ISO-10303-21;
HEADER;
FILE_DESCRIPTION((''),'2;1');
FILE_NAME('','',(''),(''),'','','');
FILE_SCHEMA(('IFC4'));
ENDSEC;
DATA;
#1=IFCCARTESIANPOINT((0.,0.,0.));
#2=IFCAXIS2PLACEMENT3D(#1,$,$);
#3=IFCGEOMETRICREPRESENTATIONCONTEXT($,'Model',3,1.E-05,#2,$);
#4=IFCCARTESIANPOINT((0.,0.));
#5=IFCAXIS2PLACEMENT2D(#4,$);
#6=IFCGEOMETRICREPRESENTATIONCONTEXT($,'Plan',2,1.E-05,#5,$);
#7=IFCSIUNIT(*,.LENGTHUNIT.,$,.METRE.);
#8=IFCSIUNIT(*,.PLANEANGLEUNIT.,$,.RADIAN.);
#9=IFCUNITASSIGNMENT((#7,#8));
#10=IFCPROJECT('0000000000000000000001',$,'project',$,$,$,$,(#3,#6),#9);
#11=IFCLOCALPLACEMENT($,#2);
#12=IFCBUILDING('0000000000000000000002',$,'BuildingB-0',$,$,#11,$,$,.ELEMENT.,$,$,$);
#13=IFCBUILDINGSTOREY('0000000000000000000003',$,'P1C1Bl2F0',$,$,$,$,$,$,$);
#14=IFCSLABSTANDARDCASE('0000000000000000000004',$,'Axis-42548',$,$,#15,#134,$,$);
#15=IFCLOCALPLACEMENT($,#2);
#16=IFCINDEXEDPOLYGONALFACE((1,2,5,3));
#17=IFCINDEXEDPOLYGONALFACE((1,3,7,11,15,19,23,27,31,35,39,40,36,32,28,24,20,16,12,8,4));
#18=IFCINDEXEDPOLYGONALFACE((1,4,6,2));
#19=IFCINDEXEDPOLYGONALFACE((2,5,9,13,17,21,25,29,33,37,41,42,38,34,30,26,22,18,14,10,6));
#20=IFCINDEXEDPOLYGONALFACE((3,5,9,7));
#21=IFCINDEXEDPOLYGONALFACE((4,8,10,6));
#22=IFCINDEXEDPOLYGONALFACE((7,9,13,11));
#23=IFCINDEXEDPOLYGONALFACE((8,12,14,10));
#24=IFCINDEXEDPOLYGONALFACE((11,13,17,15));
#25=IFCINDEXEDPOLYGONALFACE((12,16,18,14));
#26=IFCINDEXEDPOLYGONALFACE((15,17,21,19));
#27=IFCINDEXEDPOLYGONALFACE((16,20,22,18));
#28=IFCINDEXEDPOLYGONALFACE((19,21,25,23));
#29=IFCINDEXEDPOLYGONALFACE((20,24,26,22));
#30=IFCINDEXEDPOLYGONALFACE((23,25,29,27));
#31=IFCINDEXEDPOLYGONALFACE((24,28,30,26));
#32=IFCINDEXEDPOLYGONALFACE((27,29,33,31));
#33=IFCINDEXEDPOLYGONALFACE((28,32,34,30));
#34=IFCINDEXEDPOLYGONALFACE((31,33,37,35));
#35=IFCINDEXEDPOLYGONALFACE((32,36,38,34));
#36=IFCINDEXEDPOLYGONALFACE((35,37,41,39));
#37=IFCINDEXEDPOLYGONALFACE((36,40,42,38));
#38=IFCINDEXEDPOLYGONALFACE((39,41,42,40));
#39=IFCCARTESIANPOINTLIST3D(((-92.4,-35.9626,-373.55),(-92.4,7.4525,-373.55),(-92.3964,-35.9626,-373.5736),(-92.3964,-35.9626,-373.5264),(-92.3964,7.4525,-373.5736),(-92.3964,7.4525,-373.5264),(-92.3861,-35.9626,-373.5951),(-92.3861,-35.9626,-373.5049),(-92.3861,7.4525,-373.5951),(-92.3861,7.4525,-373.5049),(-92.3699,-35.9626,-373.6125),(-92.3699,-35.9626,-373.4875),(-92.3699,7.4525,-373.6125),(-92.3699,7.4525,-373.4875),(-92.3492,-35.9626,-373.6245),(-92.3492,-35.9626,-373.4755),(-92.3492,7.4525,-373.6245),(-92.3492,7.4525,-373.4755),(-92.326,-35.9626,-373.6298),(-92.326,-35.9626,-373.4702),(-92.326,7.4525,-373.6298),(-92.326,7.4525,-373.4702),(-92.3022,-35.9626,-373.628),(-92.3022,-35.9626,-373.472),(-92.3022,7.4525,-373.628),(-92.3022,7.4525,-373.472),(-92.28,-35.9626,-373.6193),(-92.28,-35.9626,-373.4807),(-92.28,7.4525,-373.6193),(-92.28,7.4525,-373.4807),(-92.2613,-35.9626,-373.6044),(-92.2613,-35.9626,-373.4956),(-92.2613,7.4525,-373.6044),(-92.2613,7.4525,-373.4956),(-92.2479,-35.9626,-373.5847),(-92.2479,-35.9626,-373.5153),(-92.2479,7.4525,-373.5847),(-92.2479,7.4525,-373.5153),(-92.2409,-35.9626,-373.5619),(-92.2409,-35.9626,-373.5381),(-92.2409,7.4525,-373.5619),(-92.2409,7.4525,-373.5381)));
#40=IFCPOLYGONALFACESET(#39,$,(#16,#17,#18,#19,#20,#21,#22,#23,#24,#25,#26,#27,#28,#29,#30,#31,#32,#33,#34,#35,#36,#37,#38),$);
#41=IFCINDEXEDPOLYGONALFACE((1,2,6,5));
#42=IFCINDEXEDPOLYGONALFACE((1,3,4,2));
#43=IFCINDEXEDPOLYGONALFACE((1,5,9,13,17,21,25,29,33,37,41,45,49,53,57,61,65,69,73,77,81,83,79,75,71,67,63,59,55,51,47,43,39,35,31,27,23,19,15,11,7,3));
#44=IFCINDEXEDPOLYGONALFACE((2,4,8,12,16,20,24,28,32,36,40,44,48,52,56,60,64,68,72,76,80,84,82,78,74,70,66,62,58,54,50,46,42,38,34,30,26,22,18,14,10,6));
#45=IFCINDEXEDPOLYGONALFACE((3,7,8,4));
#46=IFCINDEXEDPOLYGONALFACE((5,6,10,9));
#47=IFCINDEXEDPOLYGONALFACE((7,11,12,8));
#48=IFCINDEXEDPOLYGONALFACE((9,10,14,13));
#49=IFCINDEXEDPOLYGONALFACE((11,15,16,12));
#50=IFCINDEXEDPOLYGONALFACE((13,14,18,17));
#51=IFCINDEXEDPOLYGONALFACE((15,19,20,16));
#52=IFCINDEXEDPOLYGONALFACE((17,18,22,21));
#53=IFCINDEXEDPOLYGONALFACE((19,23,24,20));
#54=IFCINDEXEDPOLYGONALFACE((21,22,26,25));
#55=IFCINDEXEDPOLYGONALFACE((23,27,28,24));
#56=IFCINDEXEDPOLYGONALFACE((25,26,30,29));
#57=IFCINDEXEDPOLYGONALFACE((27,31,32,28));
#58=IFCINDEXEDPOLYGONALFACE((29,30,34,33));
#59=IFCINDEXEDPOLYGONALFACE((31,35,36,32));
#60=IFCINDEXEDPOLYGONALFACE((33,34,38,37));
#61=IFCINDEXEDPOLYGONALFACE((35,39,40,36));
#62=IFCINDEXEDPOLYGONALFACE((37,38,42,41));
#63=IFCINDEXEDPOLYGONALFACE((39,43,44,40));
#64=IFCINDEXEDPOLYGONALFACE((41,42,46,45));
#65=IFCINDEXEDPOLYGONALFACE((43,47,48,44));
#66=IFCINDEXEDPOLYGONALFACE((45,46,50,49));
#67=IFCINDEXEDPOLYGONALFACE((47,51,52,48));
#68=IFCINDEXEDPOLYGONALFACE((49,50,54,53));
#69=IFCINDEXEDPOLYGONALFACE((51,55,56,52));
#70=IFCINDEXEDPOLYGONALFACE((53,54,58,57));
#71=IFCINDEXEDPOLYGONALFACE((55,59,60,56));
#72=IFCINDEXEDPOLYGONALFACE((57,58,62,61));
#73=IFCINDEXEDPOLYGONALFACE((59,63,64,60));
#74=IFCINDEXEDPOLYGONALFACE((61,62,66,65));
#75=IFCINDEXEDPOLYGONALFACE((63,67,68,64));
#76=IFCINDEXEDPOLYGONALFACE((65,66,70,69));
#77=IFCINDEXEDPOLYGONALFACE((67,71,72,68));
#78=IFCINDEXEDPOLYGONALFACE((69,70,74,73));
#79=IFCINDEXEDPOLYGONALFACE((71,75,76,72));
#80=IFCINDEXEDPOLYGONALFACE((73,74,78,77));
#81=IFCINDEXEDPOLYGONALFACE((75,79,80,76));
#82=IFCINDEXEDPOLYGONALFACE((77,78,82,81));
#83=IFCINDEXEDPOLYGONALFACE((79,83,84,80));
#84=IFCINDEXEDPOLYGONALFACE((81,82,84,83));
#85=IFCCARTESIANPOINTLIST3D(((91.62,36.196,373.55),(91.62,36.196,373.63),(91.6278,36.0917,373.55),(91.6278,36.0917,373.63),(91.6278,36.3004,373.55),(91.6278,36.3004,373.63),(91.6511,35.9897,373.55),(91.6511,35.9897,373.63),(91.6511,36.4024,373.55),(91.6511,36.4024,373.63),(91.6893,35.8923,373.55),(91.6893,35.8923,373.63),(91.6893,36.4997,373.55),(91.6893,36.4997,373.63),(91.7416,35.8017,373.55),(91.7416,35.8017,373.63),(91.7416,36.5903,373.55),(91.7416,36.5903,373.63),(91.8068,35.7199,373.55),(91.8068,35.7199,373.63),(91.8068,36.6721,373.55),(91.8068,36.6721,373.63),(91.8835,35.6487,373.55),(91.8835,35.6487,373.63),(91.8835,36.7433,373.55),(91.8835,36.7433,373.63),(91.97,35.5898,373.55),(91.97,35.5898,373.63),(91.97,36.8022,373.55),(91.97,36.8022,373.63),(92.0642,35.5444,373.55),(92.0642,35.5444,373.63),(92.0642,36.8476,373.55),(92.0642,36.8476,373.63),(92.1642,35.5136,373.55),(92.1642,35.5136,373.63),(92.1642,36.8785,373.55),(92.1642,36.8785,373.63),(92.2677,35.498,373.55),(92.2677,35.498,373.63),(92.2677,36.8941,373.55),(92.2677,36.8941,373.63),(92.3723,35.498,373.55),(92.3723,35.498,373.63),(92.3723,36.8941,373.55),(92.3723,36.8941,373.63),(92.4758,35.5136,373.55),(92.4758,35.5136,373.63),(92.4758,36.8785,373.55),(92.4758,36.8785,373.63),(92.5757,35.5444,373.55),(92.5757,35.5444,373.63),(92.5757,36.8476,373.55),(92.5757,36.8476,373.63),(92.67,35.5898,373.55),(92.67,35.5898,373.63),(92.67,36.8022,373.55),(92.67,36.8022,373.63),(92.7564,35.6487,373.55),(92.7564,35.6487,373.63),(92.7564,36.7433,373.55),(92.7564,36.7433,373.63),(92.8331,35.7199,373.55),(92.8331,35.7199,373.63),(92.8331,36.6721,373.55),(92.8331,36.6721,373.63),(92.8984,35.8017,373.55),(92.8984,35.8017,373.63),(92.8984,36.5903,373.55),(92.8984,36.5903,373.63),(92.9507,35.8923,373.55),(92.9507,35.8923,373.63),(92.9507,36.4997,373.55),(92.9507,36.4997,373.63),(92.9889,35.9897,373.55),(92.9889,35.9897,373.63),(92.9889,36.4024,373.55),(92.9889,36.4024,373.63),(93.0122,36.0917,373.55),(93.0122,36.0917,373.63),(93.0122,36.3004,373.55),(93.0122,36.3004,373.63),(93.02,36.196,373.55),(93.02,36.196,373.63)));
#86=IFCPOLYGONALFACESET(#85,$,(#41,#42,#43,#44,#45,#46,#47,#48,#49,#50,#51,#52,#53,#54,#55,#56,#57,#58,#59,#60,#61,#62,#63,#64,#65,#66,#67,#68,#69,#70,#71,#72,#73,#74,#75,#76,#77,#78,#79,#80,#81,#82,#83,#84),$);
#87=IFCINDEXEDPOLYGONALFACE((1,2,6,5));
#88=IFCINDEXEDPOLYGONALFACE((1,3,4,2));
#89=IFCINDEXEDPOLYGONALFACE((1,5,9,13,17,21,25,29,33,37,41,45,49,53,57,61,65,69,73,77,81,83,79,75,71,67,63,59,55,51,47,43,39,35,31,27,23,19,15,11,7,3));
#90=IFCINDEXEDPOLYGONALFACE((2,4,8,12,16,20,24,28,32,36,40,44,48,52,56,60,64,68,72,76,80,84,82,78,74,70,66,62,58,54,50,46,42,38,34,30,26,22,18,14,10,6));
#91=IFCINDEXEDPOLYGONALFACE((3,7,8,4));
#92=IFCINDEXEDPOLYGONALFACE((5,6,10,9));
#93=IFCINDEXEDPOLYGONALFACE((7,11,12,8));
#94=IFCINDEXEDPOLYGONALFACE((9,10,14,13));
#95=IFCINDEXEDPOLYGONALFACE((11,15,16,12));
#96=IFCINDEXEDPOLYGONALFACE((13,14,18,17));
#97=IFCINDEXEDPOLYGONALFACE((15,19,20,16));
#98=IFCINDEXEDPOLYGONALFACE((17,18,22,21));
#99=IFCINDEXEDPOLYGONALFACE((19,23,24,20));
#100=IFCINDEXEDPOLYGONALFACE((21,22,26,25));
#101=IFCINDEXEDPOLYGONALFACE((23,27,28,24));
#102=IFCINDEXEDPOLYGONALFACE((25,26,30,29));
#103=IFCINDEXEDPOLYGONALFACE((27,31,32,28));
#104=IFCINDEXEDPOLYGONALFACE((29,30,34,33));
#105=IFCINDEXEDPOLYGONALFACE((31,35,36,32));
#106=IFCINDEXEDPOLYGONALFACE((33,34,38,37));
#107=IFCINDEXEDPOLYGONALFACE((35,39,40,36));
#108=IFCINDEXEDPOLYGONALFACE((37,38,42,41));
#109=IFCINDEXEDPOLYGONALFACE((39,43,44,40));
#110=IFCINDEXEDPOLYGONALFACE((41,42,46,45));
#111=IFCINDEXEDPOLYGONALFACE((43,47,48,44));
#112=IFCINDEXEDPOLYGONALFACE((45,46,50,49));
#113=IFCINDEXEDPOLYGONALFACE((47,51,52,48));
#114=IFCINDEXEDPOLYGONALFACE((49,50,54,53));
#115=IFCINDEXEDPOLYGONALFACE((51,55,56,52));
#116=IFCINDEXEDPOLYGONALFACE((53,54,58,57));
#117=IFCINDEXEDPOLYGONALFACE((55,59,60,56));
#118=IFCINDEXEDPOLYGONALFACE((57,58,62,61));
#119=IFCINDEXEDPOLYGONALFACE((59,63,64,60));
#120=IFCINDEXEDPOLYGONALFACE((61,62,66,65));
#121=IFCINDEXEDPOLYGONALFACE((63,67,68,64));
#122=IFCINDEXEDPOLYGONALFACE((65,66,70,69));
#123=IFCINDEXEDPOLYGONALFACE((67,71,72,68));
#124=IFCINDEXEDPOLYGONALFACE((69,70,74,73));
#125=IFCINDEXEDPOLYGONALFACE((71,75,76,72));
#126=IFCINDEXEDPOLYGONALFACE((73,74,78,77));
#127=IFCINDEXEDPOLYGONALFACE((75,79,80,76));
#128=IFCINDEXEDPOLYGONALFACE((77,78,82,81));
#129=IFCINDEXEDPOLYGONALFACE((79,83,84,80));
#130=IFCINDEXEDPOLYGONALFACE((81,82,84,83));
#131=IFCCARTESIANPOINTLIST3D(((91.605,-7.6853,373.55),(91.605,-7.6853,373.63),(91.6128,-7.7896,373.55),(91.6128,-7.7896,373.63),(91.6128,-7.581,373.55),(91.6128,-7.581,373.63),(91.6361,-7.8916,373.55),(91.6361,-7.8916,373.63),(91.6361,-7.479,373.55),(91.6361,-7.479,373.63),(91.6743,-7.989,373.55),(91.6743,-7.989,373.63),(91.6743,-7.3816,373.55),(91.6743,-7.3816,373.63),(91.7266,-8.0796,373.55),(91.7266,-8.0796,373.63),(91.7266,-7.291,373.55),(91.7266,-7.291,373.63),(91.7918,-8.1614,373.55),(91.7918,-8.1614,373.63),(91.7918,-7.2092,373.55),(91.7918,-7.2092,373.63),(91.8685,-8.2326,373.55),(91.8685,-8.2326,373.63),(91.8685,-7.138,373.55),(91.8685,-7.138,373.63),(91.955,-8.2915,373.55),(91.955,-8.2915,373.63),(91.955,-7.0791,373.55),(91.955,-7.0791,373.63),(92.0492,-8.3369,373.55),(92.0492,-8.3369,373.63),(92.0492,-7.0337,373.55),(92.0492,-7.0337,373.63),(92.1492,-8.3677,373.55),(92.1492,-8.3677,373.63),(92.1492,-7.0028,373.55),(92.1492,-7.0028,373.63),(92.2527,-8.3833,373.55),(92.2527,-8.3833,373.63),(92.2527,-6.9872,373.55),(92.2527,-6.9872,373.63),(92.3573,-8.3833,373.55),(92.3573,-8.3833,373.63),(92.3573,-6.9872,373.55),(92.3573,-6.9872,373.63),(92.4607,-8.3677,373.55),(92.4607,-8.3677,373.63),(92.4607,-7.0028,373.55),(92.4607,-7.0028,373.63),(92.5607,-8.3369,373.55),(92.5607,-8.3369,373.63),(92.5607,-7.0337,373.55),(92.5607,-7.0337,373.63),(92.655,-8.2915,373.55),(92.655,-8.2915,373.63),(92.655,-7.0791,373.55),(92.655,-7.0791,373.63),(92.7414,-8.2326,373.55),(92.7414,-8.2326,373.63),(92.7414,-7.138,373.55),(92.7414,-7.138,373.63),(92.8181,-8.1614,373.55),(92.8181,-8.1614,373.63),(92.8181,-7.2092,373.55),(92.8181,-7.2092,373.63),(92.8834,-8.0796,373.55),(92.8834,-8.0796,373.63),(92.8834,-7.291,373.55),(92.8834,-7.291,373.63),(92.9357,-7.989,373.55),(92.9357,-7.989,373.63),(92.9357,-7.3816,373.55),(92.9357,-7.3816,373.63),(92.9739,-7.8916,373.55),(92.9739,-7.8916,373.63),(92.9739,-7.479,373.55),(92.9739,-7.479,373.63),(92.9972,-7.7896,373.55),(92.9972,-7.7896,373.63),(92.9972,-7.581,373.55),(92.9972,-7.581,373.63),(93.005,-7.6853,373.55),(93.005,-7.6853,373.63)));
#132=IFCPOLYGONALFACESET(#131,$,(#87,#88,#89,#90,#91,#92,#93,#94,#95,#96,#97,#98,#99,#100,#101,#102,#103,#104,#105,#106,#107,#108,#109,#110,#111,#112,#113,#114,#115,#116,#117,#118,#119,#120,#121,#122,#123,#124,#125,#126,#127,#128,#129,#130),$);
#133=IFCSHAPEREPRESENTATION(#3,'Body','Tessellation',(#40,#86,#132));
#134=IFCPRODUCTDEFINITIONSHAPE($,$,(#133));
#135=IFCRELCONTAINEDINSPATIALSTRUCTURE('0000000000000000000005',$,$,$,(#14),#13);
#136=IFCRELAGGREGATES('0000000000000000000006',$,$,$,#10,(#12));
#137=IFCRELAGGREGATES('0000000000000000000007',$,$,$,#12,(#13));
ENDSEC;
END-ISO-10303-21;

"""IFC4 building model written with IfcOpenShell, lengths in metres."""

from ifc_helpers import new_model, entity, si_unit, frame, origin, origin_2d, place, context, project, spatial, circle, extrude, element, save


model = new_model("IFC4")

# Units and contexts
model_context = context("Model", 3, precision=1e-05, world=origin())
plan_context = context("Plan", 2, precision=1e-05, world=origin_2d())
ifc_project = project(units=[si_unit("LENGTHUNIT", "METRE"), si_unit("PLANEANGLEUNIT", "RADIAN")], contexts=[model_context, plan_context])

# Building, storey
building_placement = place(None, origin())
building = spatial("IfcBuilding", under=ifc_project, at=building_placement, Name="BuildingB-0", CompositionType="ELEMENT")
storey = spatial("IfcBuildingStorey", under=building, Name="P1C1Bl2F0")

# Slab
element("IfcSlabStandardCase", 1, inside=storey, Name="Axis-42548", context=model_context, shape_type="AdvancedSweptSolid", body=[
    entity("IfcSurfaceCurveSweptAreaSolid", entity("IfcCircleProfileDef", "AREA", None, None, 0.08), None, entity("IfcPolyline", [entity("IfcCartesianPoint", [92.32, 35.9626, 373.55]), entity("IfcCartesianPoint", [92.32, -7.4525, 373.55])]), None, None, entity("IfcPlane", entity("IfcAxis2Placement3D", entity("IfcCartesianPoint", [92.32, 35.9626, 373.55]), entity("IfcDirection", [0.0, 0.0, 1.0]), entity("IfcDirection", [1.0, 0.0, 0.0])))),
    extrude(circle(Radius=0.7), frame((92.32, 36.196, 373.55)), (0.0, 0.0, 1.0), 0.08),
    extrude(circle(Radius=0.7), frame((92.305, -7.6853, 373.55)), (0.0, 0.0, 1.0), 0.08),
])

save(model, "model.ifc")
